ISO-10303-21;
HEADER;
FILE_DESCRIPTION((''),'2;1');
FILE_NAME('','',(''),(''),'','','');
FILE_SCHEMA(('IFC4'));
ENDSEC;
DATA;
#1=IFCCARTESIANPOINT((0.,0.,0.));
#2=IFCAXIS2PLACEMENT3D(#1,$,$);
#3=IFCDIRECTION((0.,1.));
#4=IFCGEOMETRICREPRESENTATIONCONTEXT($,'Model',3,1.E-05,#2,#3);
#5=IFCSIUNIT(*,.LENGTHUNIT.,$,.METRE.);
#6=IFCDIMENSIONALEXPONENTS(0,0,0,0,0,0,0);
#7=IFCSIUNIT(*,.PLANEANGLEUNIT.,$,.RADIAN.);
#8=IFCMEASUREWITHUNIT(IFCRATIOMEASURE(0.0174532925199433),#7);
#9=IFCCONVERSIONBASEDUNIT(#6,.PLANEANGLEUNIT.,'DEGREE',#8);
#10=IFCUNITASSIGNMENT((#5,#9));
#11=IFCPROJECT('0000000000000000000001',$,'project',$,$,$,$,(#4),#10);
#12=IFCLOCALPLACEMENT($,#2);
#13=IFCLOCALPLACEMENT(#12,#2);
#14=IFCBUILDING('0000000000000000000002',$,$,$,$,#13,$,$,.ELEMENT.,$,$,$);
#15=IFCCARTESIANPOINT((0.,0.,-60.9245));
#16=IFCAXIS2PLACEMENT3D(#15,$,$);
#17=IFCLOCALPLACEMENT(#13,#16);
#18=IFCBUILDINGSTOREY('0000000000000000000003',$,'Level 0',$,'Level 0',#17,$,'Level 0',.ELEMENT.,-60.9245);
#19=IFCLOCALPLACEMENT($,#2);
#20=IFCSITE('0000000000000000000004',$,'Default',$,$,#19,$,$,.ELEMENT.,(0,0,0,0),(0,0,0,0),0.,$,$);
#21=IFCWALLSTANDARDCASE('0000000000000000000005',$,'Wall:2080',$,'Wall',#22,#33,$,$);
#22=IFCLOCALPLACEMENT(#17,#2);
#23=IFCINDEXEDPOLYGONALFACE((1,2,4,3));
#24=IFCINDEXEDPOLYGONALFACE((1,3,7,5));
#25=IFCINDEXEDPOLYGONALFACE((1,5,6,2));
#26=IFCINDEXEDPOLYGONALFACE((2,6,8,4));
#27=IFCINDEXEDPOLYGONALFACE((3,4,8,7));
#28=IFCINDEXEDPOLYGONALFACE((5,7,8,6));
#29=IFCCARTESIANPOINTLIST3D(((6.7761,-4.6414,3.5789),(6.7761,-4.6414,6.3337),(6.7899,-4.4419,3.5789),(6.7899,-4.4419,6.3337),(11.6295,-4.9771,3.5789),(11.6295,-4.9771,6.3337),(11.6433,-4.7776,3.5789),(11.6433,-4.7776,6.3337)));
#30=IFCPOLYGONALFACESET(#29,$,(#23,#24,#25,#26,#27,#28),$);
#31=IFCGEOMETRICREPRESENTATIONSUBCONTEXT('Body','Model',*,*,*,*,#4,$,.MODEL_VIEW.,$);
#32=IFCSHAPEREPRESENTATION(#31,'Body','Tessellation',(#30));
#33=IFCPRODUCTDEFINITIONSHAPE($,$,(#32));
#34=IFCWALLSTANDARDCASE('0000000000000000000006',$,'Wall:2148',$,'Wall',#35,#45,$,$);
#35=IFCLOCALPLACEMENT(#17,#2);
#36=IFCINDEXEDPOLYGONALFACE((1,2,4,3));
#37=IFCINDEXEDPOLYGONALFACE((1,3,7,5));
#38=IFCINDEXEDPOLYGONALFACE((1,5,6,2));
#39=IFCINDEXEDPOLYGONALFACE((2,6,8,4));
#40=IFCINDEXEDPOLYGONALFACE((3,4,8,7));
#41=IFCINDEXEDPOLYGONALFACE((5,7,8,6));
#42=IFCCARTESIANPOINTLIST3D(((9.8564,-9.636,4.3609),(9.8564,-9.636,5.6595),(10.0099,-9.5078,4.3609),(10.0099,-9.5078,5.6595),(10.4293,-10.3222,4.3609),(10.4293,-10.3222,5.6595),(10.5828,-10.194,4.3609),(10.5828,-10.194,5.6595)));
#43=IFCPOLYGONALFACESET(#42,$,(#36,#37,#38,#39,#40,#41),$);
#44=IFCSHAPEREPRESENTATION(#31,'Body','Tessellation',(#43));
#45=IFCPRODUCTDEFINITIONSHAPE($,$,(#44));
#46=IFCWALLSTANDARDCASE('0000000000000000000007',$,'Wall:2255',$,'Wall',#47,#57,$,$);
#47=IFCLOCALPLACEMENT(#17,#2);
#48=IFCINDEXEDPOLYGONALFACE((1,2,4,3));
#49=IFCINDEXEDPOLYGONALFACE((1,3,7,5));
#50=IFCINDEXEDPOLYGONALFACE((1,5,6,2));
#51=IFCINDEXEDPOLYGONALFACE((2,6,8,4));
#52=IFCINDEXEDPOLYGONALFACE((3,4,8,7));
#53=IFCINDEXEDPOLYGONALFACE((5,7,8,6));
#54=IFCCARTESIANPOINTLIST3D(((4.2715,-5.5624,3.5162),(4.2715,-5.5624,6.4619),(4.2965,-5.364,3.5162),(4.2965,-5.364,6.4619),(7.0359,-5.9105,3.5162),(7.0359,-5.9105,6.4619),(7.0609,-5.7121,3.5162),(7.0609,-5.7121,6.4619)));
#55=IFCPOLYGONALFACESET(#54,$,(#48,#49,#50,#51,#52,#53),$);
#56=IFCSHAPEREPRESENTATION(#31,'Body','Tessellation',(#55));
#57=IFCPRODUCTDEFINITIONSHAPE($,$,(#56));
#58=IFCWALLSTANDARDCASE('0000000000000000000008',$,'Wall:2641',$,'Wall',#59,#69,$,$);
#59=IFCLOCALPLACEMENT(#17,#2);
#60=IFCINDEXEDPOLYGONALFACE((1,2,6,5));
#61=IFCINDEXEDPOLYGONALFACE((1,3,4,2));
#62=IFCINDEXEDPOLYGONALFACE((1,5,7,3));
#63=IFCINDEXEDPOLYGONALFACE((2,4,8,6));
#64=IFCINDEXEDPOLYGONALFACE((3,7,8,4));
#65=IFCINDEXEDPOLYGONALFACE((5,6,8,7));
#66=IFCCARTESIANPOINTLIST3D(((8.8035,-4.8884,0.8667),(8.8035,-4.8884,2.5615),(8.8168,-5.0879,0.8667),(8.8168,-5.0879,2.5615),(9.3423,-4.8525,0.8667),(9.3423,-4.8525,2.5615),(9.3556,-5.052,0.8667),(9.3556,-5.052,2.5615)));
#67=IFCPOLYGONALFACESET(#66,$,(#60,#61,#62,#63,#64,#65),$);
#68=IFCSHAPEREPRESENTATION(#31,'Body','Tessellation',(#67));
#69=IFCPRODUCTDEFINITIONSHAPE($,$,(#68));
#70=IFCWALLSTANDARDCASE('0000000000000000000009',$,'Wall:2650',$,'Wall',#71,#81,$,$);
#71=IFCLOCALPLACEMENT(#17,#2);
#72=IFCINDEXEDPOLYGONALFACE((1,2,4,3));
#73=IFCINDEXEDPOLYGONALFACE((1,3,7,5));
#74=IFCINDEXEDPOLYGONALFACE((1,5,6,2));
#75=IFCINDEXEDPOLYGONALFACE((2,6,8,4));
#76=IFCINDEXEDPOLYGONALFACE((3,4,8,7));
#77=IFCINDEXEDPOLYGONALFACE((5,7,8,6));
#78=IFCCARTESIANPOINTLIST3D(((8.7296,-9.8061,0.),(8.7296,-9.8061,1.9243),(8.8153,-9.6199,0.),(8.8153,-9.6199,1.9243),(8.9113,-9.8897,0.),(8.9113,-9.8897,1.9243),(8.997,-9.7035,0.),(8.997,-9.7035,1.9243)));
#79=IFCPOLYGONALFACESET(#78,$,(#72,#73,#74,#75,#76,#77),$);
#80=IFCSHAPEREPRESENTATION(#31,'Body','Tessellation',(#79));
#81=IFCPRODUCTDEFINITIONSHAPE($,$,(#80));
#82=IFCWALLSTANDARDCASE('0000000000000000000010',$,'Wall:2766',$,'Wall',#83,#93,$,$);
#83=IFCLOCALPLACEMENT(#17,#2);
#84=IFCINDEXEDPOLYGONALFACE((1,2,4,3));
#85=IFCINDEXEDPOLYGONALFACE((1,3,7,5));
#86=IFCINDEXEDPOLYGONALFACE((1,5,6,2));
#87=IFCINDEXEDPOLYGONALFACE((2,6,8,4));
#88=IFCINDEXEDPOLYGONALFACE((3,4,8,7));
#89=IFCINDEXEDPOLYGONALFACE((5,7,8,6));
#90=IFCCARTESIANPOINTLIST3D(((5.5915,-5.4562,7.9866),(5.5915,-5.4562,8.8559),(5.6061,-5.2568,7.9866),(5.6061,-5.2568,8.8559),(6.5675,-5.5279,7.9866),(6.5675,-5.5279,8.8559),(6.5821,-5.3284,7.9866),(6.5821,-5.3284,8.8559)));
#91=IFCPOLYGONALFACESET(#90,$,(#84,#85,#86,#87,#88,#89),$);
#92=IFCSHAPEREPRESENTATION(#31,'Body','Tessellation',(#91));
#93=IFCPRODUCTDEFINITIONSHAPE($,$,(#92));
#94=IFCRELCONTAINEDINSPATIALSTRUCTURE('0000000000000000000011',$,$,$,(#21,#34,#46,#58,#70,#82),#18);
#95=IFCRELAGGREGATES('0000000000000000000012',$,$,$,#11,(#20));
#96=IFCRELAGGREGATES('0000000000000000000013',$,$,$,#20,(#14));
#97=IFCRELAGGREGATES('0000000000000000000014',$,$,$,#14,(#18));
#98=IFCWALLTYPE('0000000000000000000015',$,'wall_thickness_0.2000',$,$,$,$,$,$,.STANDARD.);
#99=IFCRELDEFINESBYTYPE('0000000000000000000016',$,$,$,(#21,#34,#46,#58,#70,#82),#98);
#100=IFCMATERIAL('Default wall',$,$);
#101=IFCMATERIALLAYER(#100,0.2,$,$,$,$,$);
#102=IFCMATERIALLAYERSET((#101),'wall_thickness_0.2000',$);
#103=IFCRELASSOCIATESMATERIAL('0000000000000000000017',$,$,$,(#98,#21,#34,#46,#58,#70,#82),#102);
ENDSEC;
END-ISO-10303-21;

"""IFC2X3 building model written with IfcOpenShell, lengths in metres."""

from ifc_helpers import new_model, entity, si_unit, converted_unit, direction, frame, origin, place, context, subcontext, project, spatial, polyline, outline, extrude, material, layer, layer_set, layer_usage, type_object, element, save


model = new_model("IFC2X3")

# Units and contexts
model_context = context("Model", 3, precision=1e-05, world=origin(), true_north=direction((0.0, 1.0)))
body_context = subcontext(model_context, "Body", "Model", "MODEL_VIEW")
ifc_project = project(units=[si_unit("LENGTHUNIT", "METRE"), converted_unit("PLANEANGLEUNIT", "DEGREE", entity("IfcRatioMeasure", 0.0174532925199433), si_unit("PLANEANGLEUNIT", "RADIAN"), dimensions=[0, 0, 0, 0, 0, 0, 0])], contexts=[model_context])

# Site, building, storey
site_placement = place(None, origin())
site = spatial("IfcSite", under=ifc_project, at=site_placement, Name="Default", CompositionType="ELEMENT", RefLatitude=(0, 0, 0, 0), RefLongitude=(0, 0, 0, 0), RefElevation=0.0)
placement_1 = place(None, origin())
building_placement = place(placement_1, origin())
building = spatial("IfcBuilding", under=site, at=building_placement, CompositionType="ELEMENT")
storey_placement = place(building_placement, frame((0.0, 0.0, -60.9245)))
storey = spatial("IfcBuildingStorey", under=building, at=storey_placement, Name="Level 0", ObjectType="Level 0", LongName="Level 0", CompositionType="ELEMENT", Elevation=-60.9245)

# Walls
ifc_material = material(Name="Default wall")
ifc_layer = layer(ifc_material, 0.2)
ifc_layer_set = layer_set([ifc_layer], Name="wall_thickness_0.2000")
ifc_layer_usage = layer_usage(ifc_layer_set, "AXIS2", "POSITIVE", -0.1)
wall_type = type_object("IfcWallType", Name="wall_thickness_0.2000", PredefinedType="STANDARD", material=ifc_layer_set)
placement_2 = place(building_placement, frame((0.0, 0.0, -57.3456)))
wall_1_placement = place(placement_2, frame((6.783, -4.5417, 0.0), z_axis=(0.0, 0.0, 1.0), x_axis=(0.997617, -0.069002, 0.0)))
element("IfcWallStandardCase", 1, at=wall_1_placement, inside=storey, type_object=wall_type, material=ifc_layer_usage, Name="Wall:2080", ObjectType="Wall", context=body_context, shape_type="SweptSolid", body=[
    extrude(outline(polyline([(4.865, -0.1), (4.865, 0.1), (0.0, 0.1), (0.0, -0.1), (4.865, -0.1)])), origin(), (0.0, 0.0, 1.0), 2.7547),
])
placement_3 = place(building_placement, frame((0.0, 0.0, -56.5636)))
wall_2_placement = place(placement_3, frame((9.9331, -9.5719, 0.0), z_axis=(0.0, 0.0, 1.0), x_axis=(0.640942, -0.76759, 0.0)))
element("IfcWallStandardCase", 2, at=wall_2_placement, inside=storey, type_object=wall_type, material=ifc_layer_usage, Name="Wall:2148", ObjectType="Wall", context=body_context, shape_type="SweptSolid", body=[
    extrude(outline(polyline([(0.8939, -0.1), (0.8939, 0.1), (0.0, 0.1), (0.0, -0.1), (0.8939, -0.1)])), origin(), (0.0, 0.0, 1.0), 1.2985),
])
placement_4 = place(building_placement, frame((0.0, 0.0, -57.4083)))
wall_3_placement = place(placement_4, frame((7.0484, -5.8113, 0.0), z_axis=(0.0, 0.0, 1.0), x_axis=(-0.992165, 0.124932, 0.0)))
element("IfcWallStandardCase", 3, at=wall_3_placement, inside=storey, type_object=wall_type, material=ifc_layer_usage, Name="Wall:2255", ObjectType="Wall", context=body_context, shape_type="SweptSolid", body=[
    extrude(outline(polyline([(2.7862, -0.1), (2.7862, 0.1), (0.0, 0.1), (0.0, -0.1), (2.7862, -0.1)])), origin(), (0.0, 0.0, 1.0), 2.9457),
])
placement_5 = place(building_placement, frame((0.0, 0.0, -60.0578)))
wall_4_placement = place(placement_5, frame((9.3489, -4.9523, 0.0), z_axis=(0.0, 0.0, 1.0), x_axis=(-0.997787, -0.066492, 0.0)))
element("IfcWallStandardCase", 4, at=wall_4_placement, inside=storey, type_object=wall_type, material=ifc_layer_usage, Name="Wall:2641", ObjectType="Wall", context=body_context, shape_type="SweptSolid", body=[
    extrude(outline(polyline([(0.54, -0.1), (0.54, 0.1), (0.0, 0.1), (0.0, -0.1), (0.54, -0.1)])), origin(), (0.0, 0.0, 1.0), 1.6948),
])
wall_5_placement = place(storey_placement, frame((8.9062, -9.6617, 0.0), z_axis=(0.0, 0.0, 1.0), x_axis=(-0.418142, -0.908382, 0.0)))
element("IfcWallStandardCase", 5, at=wall_5_placement, inside=storey, type_object=wall_type, material=ifc_layer_usage, Name="Wall:2650", ObjectType="Wall", context=body_context, shape_type="SweptSolid", body=[
    extrude(outline(polyline([(0.205, -0.1), (0.205, 0.1), (0.0, 0.1), (0.0, -0.1), (0.205, -0.1)])), origin(), (0.0, 0.0, 1.0), 1.9243),
])
placement_6 = place(building_placement, frame((0.0, 0.0, -52.9379)))
wall_6_placement = place(placement_6, frame((5.5988, -5.3565, 0.0), z_axis=(0.0, 0.0, 1.0), x_axis=(0.997317, -0.073206, 0.0)))
element("IfcWallStandardCase", 6, at=wall_6_placement, inside=storey, type_object=wall_type, material=ifc_layer_usage, Name="Wall:2766", ObjectType="Wall", context=body_context, shape_type="SweptSolid", body=[
    extrude(outline(polyline([(0.9786, -0.1), (0.9786, 0.1), (0.0, 0.1), (0.0, -0.1), (0.9786, -0.1)])), origin(), (0.0, 0.0, 1.0), 0.8693),
])

save(model, "model.ifc")
